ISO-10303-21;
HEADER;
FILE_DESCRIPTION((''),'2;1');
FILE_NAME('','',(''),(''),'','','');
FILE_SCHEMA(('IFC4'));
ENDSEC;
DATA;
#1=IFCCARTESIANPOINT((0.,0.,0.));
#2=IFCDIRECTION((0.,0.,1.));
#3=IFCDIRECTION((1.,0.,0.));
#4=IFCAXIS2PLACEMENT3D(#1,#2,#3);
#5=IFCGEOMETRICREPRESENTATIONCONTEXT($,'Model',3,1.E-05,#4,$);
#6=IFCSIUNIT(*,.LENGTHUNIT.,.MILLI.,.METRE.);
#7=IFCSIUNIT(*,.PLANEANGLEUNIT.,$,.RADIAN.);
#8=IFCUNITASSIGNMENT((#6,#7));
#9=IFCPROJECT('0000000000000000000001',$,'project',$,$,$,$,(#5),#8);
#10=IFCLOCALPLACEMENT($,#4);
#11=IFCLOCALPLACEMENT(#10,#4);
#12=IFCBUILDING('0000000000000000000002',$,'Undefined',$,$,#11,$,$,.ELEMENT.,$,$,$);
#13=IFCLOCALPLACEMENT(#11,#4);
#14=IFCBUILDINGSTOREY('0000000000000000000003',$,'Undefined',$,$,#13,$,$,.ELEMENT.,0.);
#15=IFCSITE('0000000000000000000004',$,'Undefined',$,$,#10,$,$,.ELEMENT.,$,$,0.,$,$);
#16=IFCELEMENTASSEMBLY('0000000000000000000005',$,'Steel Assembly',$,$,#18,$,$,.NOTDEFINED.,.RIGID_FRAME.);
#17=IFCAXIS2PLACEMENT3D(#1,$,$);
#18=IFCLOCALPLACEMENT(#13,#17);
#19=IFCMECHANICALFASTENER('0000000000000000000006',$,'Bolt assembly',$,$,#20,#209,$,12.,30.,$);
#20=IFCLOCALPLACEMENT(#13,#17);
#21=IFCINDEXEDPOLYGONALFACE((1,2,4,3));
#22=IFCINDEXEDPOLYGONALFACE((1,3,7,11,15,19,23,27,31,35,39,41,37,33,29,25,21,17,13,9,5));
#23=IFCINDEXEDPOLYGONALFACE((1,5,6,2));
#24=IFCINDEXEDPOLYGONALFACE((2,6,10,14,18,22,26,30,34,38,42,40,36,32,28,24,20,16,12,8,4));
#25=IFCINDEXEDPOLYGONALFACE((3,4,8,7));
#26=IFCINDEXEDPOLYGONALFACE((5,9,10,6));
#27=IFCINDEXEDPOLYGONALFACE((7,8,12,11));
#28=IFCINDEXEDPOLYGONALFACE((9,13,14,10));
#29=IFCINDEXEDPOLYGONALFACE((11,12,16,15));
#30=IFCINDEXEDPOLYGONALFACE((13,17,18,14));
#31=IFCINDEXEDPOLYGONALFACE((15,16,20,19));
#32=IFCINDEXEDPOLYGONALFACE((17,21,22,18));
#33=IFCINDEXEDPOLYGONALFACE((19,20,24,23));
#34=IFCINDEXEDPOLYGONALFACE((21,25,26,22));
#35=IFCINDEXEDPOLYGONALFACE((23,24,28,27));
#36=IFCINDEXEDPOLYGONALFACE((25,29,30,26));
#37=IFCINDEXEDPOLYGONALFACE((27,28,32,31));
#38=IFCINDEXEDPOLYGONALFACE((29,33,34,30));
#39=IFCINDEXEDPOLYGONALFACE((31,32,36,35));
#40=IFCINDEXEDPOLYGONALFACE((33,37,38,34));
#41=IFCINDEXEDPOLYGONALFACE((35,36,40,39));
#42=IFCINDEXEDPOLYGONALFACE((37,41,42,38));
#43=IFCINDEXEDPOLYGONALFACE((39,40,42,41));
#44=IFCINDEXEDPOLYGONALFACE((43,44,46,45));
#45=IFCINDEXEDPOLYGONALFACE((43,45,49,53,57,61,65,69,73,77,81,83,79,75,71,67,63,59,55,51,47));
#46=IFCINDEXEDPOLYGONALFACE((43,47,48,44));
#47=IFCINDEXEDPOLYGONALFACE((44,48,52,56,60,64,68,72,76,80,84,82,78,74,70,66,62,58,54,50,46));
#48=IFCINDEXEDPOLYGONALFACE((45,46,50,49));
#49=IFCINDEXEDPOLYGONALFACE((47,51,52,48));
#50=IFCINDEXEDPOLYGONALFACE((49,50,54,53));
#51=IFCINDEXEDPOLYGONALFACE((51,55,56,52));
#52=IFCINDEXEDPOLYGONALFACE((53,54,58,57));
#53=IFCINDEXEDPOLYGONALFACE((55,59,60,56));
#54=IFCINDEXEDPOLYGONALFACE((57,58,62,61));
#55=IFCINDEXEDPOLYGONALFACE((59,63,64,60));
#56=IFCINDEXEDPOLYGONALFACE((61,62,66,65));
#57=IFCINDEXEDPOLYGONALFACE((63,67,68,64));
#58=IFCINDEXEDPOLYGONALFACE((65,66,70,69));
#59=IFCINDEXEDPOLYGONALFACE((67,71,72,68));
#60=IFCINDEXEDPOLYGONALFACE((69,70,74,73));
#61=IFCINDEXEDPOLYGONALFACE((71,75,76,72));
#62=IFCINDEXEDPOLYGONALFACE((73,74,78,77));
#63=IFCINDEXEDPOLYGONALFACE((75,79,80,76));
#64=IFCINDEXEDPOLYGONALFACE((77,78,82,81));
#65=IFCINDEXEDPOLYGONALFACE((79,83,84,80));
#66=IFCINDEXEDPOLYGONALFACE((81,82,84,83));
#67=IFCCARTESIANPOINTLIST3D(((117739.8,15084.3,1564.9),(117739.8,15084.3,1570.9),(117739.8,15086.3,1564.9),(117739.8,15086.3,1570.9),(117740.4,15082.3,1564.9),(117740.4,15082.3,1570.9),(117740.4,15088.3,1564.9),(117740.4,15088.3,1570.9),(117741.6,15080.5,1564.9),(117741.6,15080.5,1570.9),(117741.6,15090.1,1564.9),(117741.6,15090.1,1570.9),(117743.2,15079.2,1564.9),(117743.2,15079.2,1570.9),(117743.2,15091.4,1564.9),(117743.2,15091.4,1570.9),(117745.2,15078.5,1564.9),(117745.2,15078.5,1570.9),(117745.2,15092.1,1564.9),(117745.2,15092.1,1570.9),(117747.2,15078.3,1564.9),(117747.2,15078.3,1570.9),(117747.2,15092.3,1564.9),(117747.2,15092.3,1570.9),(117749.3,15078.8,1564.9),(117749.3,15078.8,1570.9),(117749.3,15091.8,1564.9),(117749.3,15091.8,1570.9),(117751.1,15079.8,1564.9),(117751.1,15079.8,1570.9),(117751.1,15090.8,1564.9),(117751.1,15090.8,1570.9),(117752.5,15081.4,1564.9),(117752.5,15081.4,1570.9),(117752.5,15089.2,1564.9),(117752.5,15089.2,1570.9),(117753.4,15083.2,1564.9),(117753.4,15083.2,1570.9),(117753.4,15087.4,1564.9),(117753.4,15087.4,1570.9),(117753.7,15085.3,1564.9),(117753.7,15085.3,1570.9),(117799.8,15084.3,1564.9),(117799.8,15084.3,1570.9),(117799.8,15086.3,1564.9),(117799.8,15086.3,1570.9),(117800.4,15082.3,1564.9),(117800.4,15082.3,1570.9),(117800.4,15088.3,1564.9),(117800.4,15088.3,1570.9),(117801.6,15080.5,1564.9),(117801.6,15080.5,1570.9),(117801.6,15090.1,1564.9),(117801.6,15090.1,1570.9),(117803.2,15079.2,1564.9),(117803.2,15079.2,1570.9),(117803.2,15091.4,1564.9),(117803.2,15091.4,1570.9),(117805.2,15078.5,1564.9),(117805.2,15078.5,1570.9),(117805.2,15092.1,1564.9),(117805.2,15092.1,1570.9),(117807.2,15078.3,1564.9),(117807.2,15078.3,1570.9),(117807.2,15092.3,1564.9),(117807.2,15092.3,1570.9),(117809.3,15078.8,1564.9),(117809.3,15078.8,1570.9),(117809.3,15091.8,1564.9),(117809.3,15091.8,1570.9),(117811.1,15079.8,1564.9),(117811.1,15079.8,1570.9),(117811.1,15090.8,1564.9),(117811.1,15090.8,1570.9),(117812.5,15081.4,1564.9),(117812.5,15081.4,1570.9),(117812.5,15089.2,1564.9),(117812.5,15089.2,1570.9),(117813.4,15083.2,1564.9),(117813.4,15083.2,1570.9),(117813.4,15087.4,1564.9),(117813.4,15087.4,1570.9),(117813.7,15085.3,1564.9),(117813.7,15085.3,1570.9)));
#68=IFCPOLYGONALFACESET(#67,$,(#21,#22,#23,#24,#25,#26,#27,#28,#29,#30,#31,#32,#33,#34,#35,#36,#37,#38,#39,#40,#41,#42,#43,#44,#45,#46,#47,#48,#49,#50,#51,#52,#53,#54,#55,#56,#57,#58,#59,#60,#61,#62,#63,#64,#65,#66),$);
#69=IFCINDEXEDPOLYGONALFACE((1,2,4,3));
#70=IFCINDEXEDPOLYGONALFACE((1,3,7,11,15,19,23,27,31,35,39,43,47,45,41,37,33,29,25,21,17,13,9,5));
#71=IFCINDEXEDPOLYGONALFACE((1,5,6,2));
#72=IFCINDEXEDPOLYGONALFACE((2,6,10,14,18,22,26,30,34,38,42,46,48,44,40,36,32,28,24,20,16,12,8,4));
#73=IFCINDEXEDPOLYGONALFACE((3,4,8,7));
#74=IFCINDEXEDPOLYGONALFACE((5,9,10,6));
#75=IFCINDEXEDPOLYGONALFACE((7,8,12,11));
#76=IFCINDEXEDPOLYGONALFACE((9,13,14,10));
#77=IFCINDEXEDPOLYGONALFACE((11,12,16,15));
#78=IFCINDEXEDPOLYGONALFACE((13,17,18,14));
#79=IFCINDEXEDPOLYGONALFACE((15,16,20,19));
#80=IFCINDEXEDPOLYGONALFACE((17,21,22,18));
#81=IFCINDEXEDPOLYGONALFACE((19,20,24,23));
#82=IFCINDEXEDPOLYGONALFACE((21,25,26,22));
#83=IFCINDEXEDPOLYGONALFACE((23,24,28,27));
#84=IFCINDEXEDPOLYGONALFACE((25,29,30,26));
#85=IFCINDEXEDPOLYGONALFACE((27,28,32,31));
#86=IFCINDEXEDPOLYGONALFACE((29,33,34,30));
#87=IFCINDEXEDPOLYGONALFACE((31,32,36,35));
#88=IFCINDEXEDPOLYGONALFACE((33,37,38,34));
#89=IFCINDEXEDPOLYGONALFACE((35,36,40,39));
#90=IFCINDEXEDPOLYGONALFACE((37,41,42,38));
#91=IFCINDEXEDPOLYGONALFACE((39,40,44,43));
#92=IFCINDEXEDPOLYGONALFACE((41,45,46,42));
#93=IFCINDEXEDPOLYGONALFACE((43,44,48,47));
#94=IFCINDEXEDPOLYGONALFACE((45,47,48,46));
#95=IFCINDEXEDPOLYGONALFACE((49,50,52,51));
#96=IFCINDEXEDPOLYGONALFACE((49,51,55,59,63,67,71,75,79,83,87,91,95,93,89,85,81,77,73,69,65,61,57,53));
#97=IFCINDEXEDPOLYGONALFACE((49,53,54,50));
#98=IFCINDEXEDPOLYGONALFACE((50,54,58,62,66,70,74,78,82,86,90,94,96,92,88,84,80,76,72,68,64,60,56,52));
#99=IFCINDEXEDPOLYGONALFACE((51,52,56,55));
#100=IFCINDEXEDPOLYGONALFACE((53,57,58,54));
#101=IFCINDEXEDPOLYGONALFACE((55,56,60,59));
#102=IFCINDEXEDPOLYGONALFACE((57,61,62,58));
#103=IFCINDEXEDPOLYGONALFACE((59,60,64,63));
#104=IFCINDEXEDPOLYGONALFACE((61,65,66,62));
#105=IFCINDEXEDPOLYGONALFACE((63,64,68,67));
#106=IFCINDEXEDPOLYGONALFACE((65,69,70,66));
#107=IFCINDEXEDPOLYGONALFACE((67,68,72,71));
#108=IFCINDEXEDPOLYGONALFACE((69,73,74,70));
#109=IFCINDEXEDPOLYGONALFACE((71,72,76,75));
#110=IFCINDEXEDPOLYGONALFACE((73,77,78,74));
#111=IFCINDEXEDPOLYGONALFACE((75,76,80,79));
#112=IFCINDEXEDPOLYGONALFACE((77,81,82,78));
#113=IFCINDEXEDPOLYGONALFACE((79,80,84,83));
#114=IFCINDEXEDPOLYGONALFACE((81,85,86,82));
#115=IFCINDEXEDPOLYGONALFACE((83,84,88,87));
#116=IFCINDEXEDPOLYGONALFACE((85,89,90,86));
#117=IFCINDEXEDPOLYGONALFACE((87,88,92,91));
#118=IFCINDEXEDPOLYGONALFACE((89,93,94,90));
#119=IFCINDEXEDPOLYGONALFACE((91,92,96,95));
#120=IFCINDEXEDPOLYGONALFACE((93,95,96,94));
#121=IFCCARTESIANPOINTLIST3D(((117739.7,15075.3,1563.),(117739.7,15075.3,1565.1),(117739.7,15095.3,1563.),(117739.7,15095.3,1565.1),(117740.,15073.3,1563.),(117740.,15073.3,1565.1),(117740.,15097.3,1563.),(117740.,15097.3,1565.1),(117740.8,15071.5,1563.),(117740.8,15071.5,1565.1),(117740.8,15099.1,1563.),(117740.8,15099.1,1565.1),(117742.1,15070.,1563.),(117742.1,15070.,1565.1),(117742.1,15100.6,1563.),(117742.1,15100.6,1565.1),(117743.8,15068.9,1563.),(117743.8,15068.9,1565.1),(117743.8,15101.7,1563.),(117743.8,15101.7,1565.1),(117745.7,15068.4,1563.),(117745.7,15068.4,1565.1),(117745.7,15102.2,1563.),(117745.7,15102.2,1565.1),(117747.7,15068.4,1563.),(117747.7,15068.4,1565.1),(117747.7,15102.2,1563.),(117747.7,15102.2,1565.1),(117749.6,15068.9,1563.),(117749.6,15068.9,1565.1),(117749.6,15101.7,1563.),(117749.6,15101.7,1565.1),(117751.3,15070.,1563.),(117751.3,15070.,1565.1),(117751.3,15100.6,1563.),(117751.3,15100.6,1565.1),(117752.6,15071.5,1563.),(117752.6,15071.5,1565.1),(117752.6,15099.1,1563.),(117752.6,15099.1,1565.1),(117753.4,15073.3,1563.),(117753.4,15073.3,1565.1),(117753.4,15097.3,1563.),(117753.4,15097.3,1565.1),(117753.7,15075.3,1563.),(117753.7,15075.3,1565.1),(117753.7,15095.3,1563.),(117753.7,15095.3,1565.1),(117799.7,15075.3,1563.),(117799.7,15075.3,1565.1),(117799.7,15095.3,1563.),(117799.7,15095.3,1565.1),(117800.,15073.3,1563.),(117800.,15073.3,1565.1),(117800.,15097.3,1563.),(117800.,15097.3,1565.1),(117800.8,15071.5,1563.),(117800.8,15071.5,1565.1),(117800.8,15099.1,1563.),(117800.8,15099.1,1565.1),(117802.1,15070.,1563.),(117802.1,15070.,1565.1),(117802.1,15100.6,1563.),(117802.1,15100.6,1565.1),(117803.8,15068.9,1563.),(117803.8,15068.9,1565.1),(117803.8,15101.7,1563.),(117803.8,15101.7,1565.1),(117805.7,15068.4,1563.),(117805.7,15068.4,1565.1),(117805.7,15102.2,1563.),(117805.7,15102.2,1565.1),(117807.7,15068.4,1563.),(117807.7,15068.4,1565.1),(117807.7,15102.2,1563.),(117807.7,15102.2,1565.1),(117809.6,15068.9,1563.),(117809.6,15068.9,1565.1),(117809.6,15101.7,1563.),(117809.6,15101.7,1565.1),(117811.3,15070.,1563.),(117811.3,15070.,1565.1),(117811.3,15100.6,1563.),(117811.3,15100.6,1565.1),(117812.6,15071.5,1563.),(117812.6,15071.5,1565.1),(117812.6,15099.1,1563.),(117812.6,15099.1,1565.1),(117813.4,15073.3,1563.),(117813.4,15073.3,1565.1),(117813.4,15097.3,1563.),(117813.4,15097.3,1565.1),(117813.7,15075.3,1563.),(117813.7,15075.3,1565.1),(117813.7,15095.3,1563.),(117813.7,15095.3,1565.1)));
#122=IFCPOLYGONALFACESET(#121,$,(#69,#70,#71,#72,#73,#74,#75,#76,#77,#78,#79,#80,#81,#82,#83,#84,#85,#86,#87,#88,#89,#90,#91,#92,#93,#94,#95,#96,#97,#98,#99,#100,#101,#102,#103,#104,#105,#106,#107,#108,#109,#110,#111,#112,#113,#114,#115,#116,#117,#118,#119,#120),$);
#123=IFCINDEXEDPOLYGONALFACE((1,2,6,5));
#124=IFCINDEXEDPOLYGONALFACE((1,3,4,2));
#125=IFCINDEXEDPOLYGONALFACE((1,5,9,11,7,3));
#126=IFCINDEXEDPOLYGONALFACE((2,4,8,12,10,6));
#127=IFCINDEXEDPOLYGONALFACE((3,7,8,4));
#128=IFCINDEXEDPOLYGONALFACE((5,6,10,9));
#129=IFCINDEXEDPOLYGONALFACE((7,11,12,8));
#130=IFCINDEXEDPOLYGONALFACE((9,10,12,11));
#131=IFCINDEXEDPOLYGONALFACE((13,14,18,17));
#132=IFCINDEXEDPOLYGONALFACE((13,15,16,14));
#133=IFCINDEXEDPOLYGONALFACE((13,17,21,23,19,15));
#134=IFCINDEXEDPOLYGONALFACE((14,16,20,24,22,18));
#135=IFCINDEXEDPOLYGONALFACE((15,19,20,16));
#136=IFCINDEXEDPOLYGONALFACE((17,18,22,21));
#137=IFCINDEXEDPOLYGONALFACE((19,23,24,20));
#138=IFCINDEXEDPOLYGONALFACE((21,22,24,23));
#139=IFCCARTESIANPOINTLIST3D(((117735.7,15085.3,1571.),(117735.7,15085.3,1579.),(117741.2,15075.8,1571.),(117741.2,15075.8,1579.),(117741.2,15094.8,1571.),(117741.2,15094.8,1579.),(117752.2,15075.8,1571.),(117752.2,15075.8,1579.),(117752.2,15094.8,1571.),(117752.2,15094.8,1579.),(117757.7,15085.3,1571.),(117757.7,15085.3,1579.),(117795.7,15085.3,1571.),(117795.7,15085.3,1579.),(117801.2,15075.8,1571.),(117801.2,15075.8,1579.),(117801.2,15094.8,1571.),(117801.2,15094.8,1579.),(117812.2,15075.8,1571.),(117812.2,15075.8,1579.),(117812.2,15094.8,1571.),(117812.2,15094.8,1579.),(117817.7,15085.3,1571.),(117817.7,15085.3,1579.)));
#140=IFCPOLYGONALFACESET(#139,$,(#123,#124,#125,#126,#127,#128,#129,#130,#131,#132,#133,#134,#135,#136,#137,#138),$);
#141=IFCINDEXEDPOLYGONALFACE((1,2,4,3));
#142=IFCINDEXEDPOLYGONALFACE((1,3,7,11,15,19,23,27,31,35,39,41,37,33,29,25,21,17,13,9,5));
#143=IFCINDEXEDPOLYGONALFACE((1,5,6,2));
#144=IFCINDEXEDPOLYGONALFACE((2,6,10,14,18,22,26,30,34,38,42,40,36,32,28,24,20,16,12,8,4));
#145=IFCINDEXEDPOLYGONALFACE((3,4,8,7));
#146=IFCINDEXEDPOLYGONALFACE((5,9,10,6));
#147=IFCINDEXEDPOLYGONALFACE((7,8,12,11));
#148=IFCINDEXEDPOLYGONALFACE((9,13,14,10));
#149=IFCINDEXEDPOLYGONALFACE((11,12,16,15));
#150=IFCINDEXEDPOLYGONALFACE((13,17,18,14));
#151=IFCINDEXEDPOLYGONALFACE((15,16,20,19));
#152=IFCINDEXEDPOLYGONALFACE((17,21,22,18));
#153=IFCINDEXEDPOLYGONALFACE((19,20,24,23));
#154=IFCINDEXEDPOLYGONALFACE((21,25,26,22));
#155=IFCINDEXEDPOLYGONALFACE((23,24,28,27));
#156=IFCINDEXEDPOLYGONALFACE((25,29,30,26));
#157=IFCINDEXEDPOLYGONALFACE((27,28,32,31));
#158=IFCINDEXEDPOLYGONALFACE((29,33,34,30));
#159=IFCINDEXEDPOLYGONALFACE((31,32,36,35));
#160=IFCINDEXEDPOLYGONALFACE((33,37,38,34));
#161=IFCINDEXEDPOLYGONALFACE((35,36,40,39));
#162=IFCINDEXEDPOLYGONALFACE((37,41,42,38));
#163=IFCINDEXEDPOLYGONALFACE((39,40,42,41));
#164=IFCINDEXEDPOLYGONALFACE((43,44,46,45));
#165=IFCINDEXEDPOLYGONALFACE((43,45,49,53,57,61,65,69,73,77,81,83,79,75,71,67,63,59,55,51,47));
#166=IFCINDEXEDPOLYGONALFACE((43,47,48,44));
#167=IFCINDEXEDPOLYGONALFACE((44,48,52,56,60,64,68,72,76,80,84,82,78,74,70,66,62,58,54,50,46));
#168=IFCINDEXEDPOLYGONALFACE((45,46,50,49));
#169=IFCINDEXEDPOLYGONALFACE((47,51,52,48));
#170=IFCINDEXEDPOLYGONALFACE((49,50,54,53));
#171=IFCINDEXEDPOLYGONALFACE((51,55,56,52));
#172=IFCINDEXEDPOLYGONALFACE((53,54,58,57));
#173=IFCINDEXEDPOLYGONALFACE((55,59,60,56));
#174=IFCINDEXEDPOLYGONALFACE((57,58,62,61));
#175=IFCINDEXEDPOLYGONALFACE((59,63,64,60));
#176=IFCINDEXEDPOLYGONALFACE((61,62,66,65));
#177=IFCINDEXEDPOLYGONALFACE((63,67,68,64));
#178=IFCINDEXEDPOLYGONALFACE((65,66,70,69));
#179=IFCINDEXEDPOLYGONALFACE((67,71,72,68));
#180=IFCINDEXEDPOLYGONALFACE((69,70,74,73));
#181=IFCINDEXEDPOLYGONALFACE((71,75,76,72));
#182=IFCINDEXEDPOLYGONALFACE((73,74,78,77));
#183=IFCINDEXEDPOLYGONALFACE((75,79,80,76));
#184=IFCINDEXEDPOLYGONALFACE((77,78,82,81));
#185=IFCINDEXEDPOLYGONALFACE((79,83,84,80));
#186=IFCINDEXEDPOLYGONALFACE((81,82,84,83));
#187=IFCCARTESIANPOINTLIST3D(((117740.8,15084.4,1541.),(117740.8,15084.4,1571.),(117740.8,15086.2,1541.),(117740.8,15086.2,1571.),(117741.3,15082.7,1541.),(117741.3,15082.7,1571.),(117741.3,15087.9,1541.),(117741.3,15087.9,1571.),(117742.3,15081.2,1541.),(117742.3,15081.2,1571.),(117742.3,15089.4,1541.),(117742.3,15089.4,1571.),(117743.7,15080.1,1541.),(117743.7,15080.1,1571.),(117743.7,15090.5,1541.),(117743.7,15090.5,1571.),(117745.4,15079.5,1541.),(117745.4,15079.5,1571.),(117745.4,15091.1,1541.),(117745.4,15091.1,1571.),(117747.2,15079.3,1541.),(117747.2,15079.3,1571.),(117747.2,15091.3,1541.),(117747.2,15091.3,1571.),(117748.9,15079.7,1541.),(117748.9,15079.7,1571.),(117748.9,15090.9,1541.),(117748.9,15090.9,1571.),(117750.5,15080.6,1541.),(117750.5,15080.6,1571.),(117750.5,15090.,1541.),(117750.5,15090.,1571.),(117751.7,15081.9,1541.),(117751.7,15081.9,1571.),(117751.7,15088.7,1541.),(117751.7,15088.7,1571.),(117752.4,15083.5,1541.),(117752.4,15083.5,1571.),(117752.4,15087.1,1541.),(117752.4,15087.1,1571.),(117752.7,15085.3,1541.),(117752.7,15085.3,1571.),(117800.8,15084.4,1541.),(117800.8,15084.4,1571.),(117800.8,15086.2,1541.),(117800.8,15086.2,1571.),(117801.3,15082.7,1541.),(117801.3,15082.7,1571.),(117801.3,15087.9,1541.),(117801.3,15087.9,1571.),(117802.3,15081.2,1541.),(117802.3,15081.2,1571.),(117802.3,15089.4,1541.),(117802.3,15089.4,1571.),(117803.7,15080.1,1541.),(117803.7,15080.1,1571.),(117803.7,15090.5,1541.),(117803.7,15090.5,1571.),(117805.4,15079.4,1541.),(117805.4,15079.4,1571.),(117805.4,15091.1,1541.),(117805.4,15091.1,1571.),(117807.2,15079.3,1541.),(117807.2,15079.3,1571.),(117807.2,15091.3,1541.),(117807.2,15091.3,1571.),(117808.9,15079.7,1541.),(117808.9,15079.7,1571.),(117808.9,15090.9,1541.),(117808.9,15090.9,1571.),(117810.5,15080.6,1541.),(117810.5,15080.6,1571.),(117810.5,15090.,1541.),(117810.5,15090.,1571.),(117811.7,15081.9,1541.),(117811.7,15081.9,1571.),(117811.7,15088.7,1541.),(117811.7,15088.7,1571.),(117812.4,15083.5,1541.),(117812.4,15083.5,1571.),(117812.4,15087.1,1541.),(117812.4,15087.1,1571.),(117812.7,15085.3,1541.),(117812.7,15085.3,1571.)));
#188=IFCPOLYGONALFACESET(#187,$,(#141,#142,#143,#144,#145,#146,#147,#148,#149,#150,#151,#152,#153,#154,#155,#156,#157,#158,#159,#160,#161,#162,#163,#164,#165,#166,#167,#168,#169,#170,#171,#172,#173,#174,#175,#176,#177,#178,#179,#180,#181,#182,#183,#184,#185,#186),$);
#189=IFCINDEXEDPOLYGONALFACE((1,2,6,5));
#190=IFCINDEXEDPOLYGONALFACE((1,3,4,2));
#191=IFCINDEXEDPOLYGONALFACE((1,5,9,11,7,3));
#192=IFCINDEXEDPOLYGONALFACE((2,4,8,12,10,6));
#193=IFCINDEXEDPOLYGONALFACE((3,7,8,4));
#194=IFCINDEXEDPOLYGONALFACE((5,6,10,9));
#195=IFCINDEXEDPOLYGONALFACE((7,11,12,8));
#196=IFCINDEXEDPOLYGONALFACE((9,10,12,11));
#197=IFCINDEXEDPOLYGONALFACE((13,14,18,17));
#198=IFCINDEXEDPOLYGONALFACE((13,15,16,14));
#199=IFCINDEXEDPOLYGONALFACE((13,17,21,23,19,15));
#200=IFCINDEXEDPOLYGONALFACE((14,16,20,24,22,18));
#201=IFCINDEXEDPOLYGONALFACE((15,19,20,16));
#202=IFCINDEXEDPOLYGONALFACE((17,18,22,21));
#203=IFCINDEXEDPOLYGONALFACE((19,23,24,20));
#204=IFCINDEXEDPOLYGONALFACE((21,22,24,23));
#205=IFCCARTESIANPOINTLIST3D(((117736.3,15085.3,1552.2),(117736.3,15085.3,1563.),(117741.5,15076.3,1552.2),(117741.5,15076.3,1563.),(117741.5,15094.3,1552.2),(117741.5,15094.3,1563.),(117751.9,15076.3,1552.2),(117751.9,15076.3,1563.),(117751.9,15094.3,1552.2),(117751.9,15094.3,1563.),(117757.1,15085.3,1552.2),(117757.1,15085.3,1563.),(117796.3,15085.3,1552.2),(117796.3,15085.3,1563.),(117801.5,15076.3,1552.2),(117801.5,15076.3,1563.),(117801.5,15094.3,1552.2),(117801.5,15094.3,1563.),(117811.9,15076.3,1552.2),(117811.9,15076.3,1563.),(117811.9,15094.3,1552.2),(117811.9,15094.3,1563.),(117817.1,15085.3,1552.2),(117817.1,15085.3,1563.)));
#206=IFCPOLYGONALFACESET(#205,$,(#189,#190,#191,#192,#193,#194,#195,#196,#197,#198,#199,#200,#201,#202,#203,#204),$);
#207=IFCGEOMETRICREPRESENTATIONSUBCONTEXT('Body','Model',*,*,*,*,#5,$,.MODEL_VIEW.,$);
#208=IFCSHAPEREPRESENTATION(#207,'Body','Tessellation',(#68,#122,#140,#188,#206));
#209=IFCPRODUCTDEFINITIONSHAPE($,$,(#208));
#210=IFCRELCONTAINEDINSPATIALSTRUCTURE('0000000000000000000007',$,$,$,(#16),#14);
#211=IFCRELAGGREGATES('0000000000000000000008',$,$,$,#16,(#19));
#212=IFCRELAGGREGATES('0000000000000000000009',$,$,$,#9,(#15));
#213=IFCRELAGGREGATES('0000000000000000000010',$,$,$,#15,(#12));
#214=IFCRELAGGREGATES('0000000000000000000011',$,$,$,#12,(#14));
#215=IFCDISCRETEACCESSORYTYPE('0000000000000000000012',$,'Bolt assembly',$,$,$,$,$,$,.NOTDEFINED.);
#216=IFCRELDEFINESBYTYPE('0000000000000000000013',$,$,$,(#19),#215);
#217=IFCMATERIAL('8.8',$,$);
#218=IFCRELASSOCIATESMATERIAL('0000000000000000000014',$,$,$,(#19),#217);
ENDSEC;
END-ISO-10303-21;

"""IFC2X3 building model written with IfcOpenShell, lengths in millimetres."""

from ifc_helpers import new_model, si_unit, frame, frame_2d, origin_with_axes, origin_2d_with_axis, place, context, subcontext, project, spatial, polyline, circle_curve, parameter, trimmed, segment, composite_curve, circle, outline, extrude, source, transform, mapped, material, type_object, element, aggregate, save


model = new_model("IFC2X3")

# Units and contexts
model_context = context("Model", 3, precision=1e-05, world=origin_with_axes())
body_context = subcontext(model_context, "Body", "Model", "MODEL_VIEW")
ifc_project = project(units=[si_unit("LENGTHUNIT", "METRE", prefix="MILLI"), si_unit("PLANEANGLEUNIT", "RADIAN")], contexts=[model_context])

# Site, building, storey
site_placement = place(None, origin_with_axes())
site = spatial("IfcSite", under=ifc_project, at=site_placement, Name="Undefined", CompositionType="ELEMENT", RefElevation=0.0)
building_placement = place(site_placement, origin_with_axes())
building = spatial("IfcBuilding", under=site, at=building_placement, Name="Undefined", CompositionType="ELEMENT")
storey_placement = place(building_placement, origin_with_axes())
storey = spatial("IfcBuildingStorey", under=building, at=storey_placement, Name="Undefined", CompositionType="ELEMENT", Elevation=0.0)

# Shared definitions
ifc_material_1 = material(Name="8.8")
discrete_accessory_type_1 = type_object("IfcDiscreteAccessoryType", Name="Bolt assembly")

# Element assembly, mechanical fastener
assembly_1_placement = place(storey_placement, origin_with_axes())
assembly_1 = element("IfcElementAssembly", 1, at=assembly_1_placement, inside=storey, Name="Steel Assembly", AssemblyPlace="NOTDEFINED", PredefinedType="RIGID_FRAME")
shared_shape_1 = source(origin_with_axes(), body_context, "Body", "SweptSolid", [
    extrude(circle(Radius=7.0, at=origin_2d_with_axis()), frame((0.0, -2.9, 0.0), z_axis=(0.0, 1.0, 0.0), x_axis=(1.0, 0.0, 0.0)), (0.0, 0.0, 1.0), 6.0),
    extrude(outline(composite_curve([segment(polyline([(7.0, 10.0), (7.0, -10.0)]), True, "CONTINUOUS"), segment(trimmed(circle_curve(frame_2d((0.0, -10.0), x_axis=(1.0, 0.0)), 7.0), [parameter(0.0)], [parameter(3.1416)], False, "PARAMETER"), True, "CONTINUOUS"), segment(polyline([(-7.0, -10.0), (-7.0, 10.0)]), True, "CONTINUOUS"), segment(trimmed(circle_curve(frame_2d((0.0, 10.0), x_axis=(-1.0, 0.0)), 7.0), [parameter(0.0)], [parameter(3.1416)], False, "PARAMETER"), True, "DISCONTINUOUS")], self_intersect=False)), frame((0.0, 2.9, 0.0), z_axis=(0.0, 1.0, 0.0), x_axis=(1.0, 0.0, 0.0)), (0.0, 0.0, 1.0), 2.1),
    extrude(outline(polyline([(11.0, 0.0), (5.5, 9.5), (-5.5, 9.5), (-11.0, 0.0), (-5.5, -9.5), (5.5, -9.5), (11.0, 0.0)])), frame((0.0, -11.0, 0.0), z_axis=(0.0, 1.0, 0.0), x_axis=(1.0, 0.0, 0.0)), (0.0, 0.0, 1.0), 8.0),
    extrude(circle(Radius=6.0, at=origin_2d_with_axis()), frame((0.0, -3.0, 0.0), z_axis=(0.0, 1.0, 0.0), x_axis=(1.0, 0.0, 0.0)), (0.0, 0.0, 1.0), 30.0),
    extrude(outline(polyline([(10.4, 0.0), (5.2, 9.0), (-5.2, 9.0), (-10.4, 0.0), (-5.2, -9.0), (5.2, -9.0), (10.4, 0.0)])), frame((0.0, 5.0, 0.0), z_axis=(0.0, 1.0, 0.0), x_axis=(1.0, 0.0, 0.0)), (0.0, 0.0, 1.0), 10.8),
])
mechanical_fastener_1_placement = place(assembly_1_placement, frame((117701.7, 15040.3, 1568.0), z_axis=(0.000045, 1.0, 0.0), x_axis=(1.0, -0.000045, 0.0)))
mechanical_fastener_1 = element("IfcMechanicalFastener", 2, at=mechanical_fastener_1_placement, type_object=discrete_accessory_type_1, material=ifc_material_1, Name="Bolt assembly", NominalDiameter=12.0, NominalLength=30.0, context=body_context, shape_type="MappedRepresentation", body=[
    mapped(shared_shape_1, transform((45.0, 0.0, 45.0))),
    mapped(shared_shape_1, transform((105.0, 0.0, 45.0))),
])
aggregate(assembly_1, [mechanical_fastener_1])

save(model, "model.ifc")
